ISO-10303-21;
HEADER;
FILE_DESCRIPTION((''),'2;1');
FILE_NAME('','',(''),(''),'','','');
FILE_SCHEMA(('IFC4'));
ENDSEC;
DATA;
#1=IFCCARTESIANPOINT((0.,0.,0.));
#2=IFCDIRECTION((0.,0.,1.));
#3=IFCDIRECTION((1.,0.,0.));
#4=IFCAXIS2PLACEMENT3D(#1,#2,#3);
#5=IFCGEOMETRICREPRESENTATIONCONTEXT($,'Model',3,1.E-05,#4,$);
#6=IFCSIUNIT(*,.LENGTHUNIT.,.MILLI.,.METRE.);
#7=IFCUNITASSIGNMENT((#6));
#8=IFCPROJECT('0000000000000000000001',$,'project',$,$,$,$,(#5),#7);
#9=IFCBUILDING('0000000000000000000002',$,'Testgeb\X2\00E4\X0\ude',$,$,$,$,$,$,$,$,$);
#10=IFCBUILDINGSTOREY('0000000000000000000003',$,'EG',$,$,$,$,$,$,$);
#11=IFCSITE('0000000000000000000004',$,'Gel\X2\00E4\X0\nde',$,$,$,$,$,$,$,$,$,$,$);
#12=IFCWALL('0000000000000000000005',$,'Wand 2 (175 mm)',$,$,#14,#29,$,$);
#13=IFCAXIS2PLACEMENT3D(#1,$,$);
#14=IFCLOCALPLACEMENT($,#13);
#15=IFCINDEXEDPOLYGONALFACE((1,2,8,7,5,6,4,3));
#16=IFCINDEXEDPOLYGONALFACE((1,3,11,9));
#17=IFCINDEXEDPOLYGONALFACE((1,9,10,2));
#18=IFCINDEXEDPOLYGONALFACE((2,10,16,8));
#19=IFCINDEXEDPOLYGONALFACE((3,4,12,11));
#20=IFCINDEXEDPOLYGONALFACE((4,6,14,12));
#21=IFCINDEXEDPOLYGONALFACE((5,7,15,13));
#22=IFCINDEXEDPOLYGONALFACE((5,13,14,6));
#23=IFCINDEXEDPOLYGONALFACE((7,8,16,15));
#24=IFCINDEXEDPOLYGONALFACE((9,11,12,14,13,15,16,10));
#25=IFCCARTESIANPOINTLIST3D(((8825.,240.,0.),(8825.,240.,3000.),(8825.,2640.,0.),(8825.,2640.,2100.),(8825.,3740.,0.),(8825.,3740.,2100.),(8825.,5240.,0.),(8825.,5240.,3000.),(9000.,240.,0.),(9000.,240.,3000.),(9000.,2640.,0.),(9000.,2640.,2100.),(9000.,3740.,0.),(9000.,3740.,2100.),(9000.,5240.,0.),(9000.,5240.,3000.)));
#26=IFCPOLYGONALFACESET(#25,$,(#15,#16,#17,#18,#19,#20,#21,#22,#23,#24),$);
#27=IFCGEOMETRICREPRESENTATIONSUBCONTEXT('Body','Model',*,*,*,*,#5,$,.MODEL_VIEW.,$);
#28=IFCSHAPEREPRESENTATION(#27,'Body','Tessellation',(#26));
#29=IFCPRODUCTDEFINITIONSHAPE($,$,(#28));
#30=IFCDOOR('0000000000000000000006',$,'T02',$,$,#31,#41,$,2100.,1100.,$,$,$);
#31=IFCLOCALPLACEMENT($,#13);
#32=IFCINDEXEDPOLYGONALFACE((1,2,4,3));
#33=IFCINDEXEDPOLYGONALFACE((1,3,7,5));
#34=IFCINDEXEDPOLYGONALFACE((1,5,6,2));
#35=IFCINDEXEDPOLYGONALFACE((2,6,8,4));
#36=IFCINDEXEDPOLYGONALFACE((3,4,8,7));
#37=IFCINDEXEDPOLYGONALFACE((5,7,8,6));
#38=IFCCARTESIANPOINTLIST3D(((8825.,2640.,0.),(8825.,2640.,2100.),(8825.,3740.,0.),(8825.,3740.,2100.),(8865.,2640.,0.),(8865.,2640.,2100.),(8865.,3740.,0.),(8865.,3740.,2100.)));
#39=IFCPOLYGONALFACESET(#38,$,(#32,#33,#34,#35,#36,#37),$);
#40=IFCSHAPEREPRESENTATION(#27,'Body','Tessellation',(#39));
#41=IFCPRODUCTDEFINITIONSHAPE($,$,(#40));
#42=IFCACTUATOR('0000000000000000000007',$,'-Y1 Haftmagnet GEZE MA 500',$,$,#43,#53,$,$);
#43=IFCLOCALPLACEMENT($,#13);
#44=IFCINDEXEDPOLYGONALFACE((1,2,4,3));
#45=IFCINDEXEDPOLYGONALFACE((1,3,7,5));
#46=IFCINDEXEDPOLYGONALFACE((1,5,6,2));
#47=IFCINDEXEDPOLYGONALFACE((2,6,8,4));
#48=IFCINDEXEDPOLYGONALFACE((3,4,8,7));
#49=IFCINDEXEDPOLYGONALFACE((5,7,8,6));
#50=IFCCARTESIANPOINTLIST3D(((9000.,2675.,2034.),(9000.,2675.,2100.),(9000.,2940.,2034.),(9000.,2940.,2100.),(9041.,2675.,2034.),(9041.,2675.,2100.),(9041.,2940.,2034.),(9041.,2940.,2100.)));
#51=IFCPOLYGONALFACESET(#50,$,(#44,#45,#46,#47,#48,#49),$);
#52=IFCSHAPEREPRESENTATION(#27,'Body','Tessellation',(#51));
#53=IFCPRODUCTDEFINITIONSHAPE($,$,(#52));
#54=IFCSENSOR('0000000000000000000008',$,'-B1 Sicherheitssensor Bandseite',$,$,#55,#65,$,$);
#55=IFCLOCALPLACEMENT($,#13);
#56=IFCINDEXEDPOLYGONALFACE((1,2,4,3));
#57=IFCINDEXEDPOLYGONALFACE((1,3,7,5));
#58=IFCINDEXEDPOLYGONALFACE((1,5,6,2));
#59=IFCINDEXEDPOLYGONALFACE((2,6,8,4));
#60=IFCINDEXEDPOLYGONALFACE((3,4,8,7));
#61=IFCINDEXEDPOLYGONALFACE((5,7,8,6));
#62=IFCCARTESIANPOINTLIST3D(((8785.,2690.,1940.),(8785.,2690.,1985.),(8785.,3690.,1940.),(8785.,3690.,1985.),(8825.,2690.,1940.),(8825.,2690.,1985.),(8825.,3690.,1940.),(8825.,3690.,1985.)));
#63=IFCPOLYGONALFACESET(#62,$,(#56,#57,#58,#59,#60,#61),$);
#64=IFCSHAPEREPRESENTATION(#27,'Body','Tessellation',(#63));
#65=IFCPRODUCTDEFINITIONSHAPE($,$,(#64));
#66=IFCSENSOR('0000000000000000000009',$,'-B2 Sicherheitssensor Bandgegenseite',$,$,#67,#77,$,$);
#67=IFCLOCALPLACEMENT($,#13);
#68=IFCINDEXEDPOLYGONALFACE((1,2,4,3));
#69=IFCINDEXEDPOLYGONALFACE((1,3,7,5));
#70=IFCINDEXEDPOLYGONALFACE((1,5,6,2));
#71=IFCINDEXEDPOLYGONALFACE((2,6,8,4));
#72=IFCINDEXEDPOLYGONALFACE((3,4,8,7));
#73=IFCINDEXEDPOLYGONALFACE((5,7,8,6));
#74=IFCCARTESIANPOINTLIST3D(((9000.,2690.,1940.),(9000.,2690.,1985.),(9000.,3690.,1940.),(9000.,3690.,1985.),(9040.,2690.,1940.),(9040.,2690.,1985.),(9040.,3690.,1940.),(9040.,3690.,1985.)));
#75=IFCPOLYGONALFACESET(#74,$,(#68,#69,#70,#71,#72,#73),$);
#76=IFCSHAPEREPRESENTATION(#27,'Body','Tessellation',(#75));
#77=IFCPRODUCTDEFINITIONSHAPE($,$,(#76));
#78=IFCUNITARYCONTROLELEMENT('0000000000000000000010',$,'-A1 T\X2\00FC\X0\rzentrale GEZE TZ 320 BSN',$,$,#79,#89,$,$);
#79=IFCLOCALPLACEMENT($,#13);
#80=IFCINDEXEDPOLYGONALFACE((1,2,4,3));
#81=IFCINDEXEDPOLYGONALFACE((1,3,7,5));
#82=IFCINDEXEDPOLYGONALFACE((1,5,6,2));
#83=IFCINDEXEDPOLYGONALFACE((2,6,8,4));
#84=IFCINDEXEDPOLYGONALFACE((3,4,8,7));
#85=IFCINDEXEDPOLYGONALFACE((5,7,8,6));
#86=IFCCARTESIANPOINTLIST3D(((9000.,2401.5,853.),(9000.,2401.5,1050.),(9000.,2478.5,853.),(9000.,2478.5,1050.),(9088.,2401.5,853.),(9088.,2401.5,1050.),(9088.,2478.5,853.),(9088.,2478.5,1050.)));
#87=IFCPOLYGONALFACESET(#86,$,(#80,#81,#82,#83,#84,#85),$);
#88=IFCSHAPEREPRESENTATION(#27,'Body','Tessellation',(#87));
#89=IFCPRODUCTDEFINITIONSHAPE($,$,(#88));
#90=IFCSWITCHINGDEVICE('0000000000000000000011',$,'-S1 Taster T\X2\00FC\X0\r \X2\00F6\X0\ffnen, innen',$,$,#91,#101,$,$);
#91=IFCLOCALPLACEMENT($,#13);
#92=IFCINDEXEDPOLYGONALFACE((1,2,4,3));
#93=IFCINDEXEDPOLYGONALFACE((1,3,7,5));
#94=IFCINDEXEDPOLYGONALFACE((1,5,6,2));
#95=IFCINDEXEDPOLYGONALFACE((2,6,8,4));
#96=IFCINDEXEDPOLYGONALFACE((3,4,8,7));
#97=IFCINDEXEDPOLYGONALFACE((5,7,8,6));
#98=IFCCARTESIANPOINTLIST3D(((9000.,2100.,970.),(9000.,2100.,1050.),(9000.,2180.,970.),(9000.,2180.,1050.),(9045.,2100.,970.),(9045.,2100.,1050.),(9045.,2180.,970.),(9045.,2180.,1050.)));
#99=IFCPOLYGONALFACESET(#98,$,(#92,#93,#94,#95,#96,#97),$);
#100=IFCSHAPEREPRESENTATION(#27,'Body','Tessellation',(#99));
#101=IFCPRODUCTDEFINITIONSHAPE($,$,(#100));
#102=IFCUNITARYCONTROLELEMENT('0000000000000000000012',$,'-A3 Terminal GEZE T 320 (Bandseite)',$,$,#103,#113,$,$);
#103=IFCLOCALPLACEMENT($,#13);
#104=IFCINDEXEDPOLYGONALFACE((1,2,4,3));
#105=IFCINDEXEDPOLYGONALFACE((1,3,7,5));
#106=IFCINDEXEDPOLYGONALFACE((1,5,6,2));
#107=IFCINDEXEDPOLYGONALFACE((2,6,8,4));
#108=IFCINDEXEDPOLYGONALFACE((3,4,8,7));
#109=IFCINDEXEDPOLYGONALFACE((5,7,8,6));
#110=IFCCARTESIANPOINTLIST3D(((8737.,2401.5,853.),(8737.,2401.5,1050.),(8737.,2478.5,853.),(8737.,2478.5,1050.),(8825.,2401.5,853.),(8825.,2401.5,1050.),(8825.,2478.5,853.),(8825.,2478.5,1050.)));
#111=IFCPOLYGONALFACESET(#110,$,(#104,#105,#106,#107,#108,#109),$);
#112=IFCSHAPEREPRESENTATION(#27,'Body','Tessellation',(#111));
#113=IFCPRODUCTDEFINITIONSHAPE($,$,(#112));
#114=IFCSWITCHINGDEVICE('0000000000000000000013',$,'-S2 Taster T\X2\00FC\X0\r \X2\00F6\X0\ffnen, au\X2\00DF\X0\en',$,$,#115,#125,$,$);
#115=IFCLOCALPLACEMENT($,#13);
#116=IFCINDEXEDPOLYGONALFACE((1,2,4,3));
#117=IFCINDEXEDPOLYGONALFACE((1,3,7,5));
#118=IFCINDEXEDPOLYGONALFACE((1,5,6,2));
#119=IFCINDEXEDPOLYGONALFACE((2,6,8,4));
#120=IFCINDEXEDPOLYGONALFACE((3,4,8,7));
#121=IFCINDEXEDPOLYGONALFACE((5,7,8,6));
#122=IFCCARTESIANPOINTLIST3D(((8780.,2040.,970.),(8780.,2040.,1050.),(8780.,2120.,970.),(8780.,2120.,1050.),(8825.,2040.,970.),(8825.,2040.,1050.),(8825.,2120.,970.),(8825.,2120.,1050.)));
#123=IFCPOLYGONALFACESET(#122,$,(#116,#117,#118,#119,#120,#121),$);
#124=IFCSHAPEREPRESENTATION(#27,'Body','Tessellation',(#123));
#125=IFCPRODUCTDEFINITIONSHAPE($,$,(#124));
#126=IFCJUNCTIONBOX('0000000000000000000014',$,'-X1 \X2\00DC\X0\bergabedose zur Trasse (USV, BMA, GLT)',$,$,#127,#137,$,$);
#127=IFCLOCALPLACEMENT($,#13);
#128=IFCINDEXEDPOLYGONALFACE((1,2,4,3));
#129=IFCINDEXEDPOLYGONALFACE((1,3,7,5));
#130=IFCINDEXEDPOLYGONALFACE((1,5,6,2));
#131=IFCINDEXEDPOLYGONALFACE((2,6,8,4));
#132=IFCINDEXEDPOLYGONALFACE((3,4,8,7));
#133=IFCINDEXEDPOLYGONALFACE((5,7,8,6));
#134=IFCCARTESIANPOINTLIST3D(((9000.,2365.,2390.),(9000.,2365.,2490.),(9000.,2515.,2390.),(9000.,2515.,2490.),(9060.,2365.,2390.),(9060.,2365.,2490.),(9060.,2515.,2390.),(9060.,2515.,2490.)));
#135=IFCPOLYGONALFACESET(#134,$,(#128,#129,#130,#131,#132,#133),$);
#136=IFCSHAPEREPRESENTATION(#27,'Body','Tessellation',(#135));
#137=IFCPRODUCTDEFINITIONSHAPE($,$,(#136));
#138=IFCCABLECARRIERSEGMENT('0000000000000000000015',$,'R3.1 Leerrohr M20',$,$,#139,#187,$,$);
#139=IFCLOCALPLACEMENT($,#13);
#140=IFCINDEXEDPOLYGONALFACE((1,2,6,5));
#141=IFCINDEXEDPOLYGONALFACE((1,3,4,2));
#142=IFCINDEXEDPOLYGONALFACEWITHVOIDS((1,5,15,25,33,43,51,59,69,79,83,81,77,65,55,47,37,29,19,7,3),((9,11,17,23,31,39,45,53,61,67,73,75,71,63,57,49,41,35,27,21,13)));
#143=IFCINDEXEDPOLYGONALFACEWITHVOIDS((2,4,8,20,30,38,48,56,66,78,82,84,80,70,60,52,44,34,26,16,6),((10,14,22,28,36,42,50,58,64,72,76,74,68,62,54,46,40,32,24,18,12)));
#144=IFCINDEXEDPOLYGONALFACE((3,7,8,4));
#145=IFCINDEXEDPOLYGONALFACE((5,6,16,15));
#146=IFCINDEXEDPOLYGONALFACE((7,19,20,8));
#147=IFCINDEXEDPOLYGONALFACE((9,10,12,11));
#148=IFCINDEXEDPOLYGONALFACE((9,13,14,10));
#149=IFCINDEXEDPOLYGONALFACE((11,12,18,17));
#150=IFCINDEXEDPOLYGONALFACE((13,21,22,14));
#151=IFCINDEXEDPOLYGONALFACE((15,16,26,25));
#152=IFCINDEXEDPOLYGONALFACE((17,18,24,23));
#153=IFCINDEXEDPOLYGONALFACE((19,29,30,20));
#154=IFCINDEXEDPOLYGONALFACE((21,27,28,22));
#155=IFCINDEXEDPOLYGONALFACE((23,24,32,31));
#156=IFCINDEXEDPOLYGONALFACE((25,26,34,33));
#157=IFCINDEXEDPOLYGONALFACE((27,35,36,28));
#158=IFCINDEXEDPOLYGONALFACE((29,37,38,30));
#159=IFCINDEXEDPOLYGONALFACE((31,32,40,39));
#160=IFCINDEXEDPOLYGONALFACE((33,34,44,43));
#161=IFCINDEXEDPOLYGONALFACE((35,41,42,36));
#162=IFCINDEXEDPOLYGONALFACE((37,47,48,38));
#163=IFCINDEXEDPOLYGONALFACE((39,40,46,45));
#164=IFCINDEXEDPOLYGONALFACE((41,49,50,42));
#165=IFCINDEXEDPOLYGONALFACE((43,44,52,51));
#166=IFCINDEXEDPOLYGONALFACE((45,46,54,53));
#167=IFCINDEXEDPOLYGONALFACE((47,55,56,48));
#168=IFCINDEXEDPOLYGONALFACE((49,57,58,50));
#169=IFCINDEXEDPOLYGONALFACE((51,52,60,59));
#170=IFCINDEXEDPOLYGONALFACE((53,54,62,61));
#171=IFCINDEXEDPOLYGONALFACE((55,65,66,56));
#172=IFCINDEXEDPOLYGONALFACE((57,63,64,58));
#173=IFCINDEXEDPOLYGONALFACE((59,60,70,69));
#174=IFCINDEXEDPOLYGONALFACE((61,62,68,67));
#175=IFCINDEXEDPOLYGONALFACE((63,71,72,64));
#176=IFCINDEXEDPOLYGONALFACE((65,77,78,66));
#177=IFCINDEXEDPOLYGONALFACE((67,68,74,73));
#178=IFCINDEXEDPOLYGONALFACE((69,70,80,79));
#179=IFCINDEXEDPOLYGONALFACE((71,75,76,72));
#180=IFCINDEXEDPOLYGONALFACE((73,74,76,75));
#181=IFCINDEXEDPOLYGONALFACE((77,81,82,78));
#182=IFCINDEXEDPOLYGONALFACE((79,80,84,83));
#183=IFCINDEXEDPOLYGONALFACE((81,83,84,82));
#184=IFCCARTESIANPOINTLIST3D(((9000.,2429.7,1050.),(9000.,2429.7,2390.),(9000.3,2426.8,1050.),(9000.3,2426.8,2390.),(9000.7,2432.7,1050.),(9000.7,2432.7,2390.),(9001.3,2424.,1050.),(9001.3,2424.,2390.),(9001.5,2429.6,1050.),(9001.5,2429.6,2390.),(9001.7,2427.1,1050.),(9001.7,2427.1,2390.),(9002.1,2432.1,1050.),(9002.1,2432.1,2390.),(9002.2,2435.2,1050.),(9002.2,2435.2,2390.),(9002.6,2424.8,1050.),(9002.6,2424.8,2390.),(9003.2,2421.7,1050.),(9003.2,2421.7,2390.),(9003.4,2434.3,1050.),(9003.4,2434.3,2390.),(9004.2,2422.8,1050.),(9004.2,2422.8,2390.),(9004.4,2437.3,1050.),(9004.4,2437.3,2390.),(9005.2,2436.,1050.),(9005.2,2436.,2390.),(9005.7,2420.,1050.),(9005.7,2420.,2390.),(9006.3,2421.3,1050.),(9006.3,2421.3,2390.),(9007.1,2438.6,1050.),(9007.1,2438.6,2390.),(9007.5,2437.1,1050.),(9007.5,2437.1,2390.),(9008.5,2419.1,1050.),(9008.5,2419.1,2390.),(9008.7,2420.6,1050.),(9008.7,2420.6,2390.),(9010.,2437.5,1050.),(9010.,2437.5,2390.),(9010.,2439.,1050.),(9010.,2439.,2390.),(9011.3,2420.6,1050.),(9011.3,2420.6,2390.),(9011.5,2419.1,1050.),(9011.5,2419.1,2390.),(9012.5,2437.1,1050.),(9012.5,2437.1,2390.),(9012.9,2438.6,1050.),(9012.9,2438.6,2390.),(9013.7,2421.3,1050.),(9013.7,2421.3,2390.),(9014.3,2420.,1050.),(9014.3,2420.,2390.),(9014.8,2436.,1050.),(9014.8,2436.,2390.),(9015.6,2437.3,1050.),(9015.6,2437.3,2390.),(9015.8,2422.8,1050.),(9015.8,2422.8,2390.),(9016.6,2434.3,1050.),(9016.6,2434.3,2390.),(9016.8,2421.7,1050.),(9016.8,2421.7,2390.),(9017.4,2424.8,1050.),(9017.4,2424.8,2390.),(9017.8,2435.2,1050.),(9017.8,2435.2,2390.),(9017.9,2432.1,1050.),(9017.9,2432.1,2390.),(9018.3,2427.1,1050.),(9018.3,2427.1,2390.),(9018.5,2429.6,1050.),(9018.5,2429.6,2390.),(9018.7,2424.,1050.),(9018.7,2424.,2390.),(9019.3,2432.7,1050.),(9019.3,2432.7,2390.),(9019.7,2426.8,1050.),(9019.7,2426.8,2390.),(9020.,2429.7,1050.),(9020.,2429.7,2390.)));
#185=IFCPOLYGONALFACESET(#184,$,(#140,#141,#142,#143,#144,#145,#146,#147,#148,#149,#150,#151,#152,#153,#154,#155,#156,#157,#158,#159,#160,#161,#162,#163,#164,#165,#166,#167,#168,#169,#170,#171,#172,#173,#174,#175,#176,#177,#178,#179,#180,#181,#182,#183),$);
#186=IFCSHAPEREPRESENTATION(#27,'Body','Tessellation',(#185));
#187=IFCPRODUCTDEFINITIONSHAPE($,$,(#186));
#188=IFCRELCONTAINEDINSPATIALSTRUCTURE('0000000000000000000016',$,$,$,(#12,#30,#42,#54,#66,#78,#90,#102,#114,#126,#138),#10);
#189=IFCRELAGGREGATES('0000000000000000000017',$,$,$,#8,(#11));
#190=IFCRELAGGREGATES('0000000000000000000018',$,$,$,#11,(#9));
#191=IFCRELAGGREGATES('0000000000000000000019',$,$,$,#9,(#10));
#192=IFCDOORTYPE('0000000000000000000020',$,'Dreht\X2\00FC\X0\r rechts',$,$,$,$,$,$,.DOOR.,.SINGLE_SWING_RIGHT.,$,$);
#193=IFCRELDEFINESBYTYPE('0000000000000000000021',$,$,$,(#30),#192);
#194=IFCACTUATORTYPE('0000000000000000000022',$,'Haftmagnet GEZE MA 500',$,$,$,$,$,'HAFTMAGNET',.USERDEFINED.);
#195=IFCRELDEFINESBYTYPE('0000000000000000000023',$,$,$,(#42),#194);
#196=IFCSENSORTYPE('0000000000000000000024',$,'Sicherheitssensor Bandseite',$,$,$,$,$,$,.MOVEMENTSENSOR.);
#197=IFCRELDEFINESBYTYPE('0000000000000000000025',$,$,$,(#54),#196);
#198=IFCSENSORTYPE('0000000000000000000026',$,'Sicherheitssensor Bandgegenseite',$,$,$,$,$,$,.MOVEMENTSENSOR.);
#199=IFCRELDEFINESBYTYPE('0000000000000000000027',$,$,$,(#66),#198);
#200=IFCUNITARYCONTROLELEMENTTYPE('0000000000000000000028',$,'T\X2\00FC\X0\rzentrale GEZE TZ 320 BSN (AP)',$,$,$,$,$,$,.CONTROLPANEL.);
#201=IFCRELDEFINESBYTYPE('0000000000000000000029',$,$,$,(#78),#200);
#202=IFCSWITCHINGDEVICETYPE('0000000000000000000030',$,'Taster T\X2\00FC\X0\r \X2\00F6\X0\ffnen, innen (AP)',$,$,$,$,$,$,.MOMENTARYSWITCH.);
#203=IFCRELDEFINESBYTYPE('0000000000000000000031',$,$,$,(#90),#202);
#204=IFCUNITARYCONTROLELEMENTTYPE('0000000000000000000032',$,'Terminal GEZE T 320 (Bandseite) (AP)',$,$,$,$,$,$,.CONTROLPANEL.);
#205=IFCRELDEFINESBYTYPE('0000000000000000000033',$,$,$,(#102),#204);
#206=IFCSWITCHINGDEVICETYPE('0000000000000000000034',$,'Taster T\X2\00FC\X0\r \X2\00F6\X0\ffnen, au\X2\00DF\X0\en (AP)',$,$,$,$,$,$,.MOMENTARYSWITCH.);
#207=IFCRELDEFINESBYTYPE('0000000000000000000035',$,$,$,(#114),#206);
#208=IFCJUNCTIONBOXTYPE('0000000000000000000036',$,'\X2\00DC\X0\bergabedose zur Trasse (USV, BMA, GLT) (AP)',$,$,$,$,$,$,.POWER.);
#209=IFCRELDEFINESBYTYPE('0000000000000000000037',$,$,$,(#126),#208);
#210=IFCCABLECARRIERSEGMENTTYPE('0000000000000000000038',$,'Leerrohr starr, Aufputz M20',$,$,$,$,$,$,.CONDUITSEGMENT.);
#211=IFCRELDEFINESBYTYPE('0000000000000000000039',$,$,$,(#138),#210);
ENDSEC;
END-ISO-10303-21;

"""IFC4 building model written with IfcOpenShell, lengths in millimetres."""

from ifc_helpers import new_model, si_unit, frame, frame_2d, origin_with_axes, place, context, subcontext, project, spatial, rectangle, hollow_circle, extrude, type_object, element, fill, save


model = new_model("IFC4")

# Units and contexts
model_context = context("Model", 3, precision=1e-05, world=origin_with_axes())
body_context = subcontext(model_context, "Body", "Model", "MODEL_VIEW")
ifc_project = project(units=[si_unit("LENGTHUNIT", "METRE", prefix="MILLI")], contexts=[model_context])

# Site, building, storey
site = spatial("IfcSite", under=ifc_project, Name="Gelände")
building = spatial("IfcBuilding", under=site, Name="Testgebäude")
storey = spatial("IfcBuildingStorey", under=building, Name="EG")

# Wall, opening, door
wall_placement = place(None, frame((9000.0, 240.0, 0.0), z_axis=(0.0, 0.0, 1.0), x_axis=(0.0, 1.0, 0.0)))
wall = element("IfcWall", 1, at=wall_placement, inside=storey, Name="Wand 2 (175 mm)", context=body_context, shape_type="SweptSolid", body=[
    extrude(rectangle(XDim=5000.0, YDim=175.0, at=frame_2d((2500.0, 87.5))), None, (0.0, 0.0, 1.0), 3000.0),
])
opening_placement = place(None, frame((9000.0, 2640.0, 0.0), z_axis=(0.0, 0.0, 1.0), x_axis=(0.0, 1.0, 0.0)))
opening = element("IfcOpeningElement", 2, at=opening_placement, cuts=wall, context=body_context, shape_type="SweptSolid", body=[
    extrude(rectangle(XDim=1100.0, YDim=175.0, at=frame_2d((550.0, 87.5))), None, (0.0, 0.0, 1.0), 2100.0),
])
door_type = type_object("IfcDoorType", Name="Drehtür rechts", OperationType="SINGLE_SWING_RIGHT", PredefinedType="DOOR")
door_placement = place(opening_placement, origin_with_axes())
door = element("IfcDoor", 3, at=door_placement, inside=storey, type_object=door_type, Name="T02", OverallHeight=2100.0, OverallWidth=1100.0, context=body_context, shape_type="SweptSolid", body=[
    extrude(rectangle(XDim=1100.0, YDim=40.0, at=frame_2d((550.0, 20.0))), frame((0.0, 135.0, 0.0)), (0.0, 0.0, 1.0), 2100.0),
])
fill(opening, door)

# Actuator
actuator_type = type_object("IfcActuatorType", Name="Haftmagnet GEZE MA 500", ElementType="HAFTMAGNET", PredefinedType="USERDEFINED")
actuator_placement = place(None, frame((9041.0, 2675.0, 2034.0), z_axis=(0.0, 0.0, 1.0), x_axis=(0.0, 1.0, 0.0)))
element("IfcActuator", 4, at=actuator_placement, inside=storey, type_object=actuator_type, Name="-Y1 Haftmagnet GEZE MA 500", context=body_context, shape_type="SweptSolid", body=[
    extrude(rectangle(XDim=265.0, YDim=41.0, at=frame_2d((132.5, 20.5))), None, (0.0, 0.0, 1.0), 66.0),
])

# Sensors
sensor_type_1 = type_object("IfcSensorType", Name="Sicherheitssensor Bandseite", PredefinedType="MOVEMENTSENSOR")
sensor_1_placement = place(None, frame((8825.0, 2690.0, 1940.0), z_axis=(0.0, 0.0, 1.0), x_axis=(0.0, 1.0, 0.0)))
element("IfcSensor", 5, at=sensor_1_placement, inside=storey, type_object=sensor_type_1, Name="-B1 Sicherheitssensor Bandseite", context=body_context, shape_type="SweptSolid", body=[
    extrude(rectangle(XDim=1000.0, YDim=40.0, at=frame_2d((500.0, 20.0))), None, (0.0, 0.0, 1.0), 45.0),
])
sensor_type_2 = type_object("IfcSensorType", Name="Sicherheitssensor Bandgegenseite", PredefinedType="MOVEMENTSENSOR")
sensor_2_placement = place(None, frame((9040.0, 2690.0, 1940.0), z_axis=(0.0, 0.0, 1.0), x_axis=(0.0, 1.0, 0.0)))
element("IfcSensor", 6, at=sensor_2_placement, inside=storey, type_object=sensor_type_2, Name="-B2 Sicherheitssensor Bandgegenseite", context=body_context, shape_type="SweptSolid", body=[
    extrude(rectangle(XDim=1000.0, YDim=40.0, at=frame_2d((500.0, 20.0))), None, (0.0, 0.0, 1.0), 45.0),
])

# Unitary control element
unitary_control_element_type_1 = type_object("IfcUnitaryControlElementType", Name="Türzentrale GEZE TZ 320 BSN (AP)", PredefinedType="CONTROLPANEL")
unitary_control_element_1_placement = place(None, frame((9088.0, 2401.5, 853.0), z_axis=(0.0, 0.0, 1.0), x_axis=(0.0, 1.0, 0.0)))
element("IfcUnitaryControlElement", 7, at=unitary_control_element_1_placement, inside=storey, type_object=unitary_control_element_type_1, Name="-A1 Türzentrale GEZE TZ 320 BSN", context=body_context, shape_type="SweptSolid", body=[
    extrude(rectangle(XDim=77.0, YDim=88.0, at=frame_2d((38.5, 44.0))), None, (0.0, 0.0, 1.0), 197.0),
])

# Switching device
switching_device_type_1 = type_object("IfcSwitchingDeviceType", Name="Taster Tür öffnen, innen (AP)", PredefinedType="MOMENTARYSWITCH")
switching_device_1_placement = place(None, frame((9045.0, 2100.0, 970.0), z_axis=(0.0, 0.0, 1.0), x_axis=(0.0, 1.0, 0.0)))
element("IfcSwitchingDevice", 8, at=switching_device_1_placement, inside=storey, type_object=switching_device_type_1, Name="-S1 Taster Tür öffnen, innen", context=body_context, shape_type="SweptSolid", body=[
    extrude(rectangle(XDim=80.0, YDim=45.0, at=frame_2d((40.0, 22.5))), None, (0.0, 0.0, 1.0), 80.0),
])

# Unitary control element
unitary_control_element_type_2 = type_object("IfcUnitaryControlElementType", Name="Terminal GEZE T 320 (Bandseite) (AP)", PredefinedType="CONTROLPANEL")
unitary_control_element_2_placement = place(None, frame((8825.0, 2401.5, 853.0), z_axis=(0.0, 0.0, 1.0), x_axis=(0.0, 1.0, 0.0)))
element("IfcUnitaryControlElement", 9, at=unitary_control_element_2_placement, inside=storey, type_object=unitary_control_element_type_2, Name="-A3 Terminal GEZE T 320 (Bandseite)", context=body_context, shape_type="SweptSolid", body=[
    extrude(rectangle(XDim=77.0, YDim=88.0, at=frame_2d((38.5, 44.0))), None, (0.0, 0.0, 1.0), 197.0),
])

# Switching device
switching_device_type_2 = type_object("IfcSwitchingDeviceType", Name="Taster Tür öffnen, außen (AP)", PredefinedType="MOMENTARYSWITCH")
switching_device_2_placement = place(None, frame((8825.0, 2040.0, 970.0), z_axis=(0.0, 0.0, 1.0), x_axis=(0.0, 1.0, 0.0)))
element("IfcSwitchingDevice", 10, at=switching_device_2_placement, inside=storey, type_object=switching_device_type_2, Name="-S2 Taster Tür öffnen, außen", context=body_context, shape_type="SweptSolid", body=[
    extrude(rectangle(XDim=80.0, YDim=45.0, at=frame_2d((40.0, 22.5))), None, (0.0, 0.0, 1.0), 80.0),
])

# Junction box
junction_box_type = type_object("IfcJunctionBoxType", Name="Übergabedose zur Trasse (USV, BMA, GLT) (AP)", PredefinedType="POWER")
junction_box_placement = place(None, frame((9060.0, 2365.0, 2390.0), z_axis=(0.0, 0.0, 1.0), x_axis=(0.0, 1.0, 0.0)))
element("IfcJunctionBox", 11, at=junction_box_placement, inside=storey, type_object=junction_box_type, Name="-X1 Übergabedose zur Trasse (USV, BMA, GLT)", context=body_context, shape_type="SweptSolid", body=[
    extrude(rectangle(XDim=150.0, YDim=60.0, at=frame_2d((75.0, 30.0))), None, (0.0, 0.0, 1.0), 100.0),
])

# Cable carrier segment
cable_carrier_segment_type_1 = type_object("IfcCableCarrierSegmentType", Name="Leerrohr starr, Aufputz M20", PredefinedType="CONDUITSEGMENT")
for number, where, z_axis, x_axis, name in (
    (12, (9010.0, 2429.0, 1050.0), (0.0, 0.0, 1.0), (0.0, 1.0, 0.0), "R3.1 Leerrohr M20"),
):
    element("IfcCableCarrierSegment", number, at=place(None, frame(where, z_axis=z_axis, x_axis=x_axis)), inside=storey, type_object=cable_carrier_segment_type_1, Name=name, context=body_context, shape_type="SweptSolid", body=[
        extrude(hollow_circle(Radius=10.0, WallThickness=1.5), None, (0.0, 0.0, 1.0), 1340.0),
    ])

save(model, "model.ifc")
